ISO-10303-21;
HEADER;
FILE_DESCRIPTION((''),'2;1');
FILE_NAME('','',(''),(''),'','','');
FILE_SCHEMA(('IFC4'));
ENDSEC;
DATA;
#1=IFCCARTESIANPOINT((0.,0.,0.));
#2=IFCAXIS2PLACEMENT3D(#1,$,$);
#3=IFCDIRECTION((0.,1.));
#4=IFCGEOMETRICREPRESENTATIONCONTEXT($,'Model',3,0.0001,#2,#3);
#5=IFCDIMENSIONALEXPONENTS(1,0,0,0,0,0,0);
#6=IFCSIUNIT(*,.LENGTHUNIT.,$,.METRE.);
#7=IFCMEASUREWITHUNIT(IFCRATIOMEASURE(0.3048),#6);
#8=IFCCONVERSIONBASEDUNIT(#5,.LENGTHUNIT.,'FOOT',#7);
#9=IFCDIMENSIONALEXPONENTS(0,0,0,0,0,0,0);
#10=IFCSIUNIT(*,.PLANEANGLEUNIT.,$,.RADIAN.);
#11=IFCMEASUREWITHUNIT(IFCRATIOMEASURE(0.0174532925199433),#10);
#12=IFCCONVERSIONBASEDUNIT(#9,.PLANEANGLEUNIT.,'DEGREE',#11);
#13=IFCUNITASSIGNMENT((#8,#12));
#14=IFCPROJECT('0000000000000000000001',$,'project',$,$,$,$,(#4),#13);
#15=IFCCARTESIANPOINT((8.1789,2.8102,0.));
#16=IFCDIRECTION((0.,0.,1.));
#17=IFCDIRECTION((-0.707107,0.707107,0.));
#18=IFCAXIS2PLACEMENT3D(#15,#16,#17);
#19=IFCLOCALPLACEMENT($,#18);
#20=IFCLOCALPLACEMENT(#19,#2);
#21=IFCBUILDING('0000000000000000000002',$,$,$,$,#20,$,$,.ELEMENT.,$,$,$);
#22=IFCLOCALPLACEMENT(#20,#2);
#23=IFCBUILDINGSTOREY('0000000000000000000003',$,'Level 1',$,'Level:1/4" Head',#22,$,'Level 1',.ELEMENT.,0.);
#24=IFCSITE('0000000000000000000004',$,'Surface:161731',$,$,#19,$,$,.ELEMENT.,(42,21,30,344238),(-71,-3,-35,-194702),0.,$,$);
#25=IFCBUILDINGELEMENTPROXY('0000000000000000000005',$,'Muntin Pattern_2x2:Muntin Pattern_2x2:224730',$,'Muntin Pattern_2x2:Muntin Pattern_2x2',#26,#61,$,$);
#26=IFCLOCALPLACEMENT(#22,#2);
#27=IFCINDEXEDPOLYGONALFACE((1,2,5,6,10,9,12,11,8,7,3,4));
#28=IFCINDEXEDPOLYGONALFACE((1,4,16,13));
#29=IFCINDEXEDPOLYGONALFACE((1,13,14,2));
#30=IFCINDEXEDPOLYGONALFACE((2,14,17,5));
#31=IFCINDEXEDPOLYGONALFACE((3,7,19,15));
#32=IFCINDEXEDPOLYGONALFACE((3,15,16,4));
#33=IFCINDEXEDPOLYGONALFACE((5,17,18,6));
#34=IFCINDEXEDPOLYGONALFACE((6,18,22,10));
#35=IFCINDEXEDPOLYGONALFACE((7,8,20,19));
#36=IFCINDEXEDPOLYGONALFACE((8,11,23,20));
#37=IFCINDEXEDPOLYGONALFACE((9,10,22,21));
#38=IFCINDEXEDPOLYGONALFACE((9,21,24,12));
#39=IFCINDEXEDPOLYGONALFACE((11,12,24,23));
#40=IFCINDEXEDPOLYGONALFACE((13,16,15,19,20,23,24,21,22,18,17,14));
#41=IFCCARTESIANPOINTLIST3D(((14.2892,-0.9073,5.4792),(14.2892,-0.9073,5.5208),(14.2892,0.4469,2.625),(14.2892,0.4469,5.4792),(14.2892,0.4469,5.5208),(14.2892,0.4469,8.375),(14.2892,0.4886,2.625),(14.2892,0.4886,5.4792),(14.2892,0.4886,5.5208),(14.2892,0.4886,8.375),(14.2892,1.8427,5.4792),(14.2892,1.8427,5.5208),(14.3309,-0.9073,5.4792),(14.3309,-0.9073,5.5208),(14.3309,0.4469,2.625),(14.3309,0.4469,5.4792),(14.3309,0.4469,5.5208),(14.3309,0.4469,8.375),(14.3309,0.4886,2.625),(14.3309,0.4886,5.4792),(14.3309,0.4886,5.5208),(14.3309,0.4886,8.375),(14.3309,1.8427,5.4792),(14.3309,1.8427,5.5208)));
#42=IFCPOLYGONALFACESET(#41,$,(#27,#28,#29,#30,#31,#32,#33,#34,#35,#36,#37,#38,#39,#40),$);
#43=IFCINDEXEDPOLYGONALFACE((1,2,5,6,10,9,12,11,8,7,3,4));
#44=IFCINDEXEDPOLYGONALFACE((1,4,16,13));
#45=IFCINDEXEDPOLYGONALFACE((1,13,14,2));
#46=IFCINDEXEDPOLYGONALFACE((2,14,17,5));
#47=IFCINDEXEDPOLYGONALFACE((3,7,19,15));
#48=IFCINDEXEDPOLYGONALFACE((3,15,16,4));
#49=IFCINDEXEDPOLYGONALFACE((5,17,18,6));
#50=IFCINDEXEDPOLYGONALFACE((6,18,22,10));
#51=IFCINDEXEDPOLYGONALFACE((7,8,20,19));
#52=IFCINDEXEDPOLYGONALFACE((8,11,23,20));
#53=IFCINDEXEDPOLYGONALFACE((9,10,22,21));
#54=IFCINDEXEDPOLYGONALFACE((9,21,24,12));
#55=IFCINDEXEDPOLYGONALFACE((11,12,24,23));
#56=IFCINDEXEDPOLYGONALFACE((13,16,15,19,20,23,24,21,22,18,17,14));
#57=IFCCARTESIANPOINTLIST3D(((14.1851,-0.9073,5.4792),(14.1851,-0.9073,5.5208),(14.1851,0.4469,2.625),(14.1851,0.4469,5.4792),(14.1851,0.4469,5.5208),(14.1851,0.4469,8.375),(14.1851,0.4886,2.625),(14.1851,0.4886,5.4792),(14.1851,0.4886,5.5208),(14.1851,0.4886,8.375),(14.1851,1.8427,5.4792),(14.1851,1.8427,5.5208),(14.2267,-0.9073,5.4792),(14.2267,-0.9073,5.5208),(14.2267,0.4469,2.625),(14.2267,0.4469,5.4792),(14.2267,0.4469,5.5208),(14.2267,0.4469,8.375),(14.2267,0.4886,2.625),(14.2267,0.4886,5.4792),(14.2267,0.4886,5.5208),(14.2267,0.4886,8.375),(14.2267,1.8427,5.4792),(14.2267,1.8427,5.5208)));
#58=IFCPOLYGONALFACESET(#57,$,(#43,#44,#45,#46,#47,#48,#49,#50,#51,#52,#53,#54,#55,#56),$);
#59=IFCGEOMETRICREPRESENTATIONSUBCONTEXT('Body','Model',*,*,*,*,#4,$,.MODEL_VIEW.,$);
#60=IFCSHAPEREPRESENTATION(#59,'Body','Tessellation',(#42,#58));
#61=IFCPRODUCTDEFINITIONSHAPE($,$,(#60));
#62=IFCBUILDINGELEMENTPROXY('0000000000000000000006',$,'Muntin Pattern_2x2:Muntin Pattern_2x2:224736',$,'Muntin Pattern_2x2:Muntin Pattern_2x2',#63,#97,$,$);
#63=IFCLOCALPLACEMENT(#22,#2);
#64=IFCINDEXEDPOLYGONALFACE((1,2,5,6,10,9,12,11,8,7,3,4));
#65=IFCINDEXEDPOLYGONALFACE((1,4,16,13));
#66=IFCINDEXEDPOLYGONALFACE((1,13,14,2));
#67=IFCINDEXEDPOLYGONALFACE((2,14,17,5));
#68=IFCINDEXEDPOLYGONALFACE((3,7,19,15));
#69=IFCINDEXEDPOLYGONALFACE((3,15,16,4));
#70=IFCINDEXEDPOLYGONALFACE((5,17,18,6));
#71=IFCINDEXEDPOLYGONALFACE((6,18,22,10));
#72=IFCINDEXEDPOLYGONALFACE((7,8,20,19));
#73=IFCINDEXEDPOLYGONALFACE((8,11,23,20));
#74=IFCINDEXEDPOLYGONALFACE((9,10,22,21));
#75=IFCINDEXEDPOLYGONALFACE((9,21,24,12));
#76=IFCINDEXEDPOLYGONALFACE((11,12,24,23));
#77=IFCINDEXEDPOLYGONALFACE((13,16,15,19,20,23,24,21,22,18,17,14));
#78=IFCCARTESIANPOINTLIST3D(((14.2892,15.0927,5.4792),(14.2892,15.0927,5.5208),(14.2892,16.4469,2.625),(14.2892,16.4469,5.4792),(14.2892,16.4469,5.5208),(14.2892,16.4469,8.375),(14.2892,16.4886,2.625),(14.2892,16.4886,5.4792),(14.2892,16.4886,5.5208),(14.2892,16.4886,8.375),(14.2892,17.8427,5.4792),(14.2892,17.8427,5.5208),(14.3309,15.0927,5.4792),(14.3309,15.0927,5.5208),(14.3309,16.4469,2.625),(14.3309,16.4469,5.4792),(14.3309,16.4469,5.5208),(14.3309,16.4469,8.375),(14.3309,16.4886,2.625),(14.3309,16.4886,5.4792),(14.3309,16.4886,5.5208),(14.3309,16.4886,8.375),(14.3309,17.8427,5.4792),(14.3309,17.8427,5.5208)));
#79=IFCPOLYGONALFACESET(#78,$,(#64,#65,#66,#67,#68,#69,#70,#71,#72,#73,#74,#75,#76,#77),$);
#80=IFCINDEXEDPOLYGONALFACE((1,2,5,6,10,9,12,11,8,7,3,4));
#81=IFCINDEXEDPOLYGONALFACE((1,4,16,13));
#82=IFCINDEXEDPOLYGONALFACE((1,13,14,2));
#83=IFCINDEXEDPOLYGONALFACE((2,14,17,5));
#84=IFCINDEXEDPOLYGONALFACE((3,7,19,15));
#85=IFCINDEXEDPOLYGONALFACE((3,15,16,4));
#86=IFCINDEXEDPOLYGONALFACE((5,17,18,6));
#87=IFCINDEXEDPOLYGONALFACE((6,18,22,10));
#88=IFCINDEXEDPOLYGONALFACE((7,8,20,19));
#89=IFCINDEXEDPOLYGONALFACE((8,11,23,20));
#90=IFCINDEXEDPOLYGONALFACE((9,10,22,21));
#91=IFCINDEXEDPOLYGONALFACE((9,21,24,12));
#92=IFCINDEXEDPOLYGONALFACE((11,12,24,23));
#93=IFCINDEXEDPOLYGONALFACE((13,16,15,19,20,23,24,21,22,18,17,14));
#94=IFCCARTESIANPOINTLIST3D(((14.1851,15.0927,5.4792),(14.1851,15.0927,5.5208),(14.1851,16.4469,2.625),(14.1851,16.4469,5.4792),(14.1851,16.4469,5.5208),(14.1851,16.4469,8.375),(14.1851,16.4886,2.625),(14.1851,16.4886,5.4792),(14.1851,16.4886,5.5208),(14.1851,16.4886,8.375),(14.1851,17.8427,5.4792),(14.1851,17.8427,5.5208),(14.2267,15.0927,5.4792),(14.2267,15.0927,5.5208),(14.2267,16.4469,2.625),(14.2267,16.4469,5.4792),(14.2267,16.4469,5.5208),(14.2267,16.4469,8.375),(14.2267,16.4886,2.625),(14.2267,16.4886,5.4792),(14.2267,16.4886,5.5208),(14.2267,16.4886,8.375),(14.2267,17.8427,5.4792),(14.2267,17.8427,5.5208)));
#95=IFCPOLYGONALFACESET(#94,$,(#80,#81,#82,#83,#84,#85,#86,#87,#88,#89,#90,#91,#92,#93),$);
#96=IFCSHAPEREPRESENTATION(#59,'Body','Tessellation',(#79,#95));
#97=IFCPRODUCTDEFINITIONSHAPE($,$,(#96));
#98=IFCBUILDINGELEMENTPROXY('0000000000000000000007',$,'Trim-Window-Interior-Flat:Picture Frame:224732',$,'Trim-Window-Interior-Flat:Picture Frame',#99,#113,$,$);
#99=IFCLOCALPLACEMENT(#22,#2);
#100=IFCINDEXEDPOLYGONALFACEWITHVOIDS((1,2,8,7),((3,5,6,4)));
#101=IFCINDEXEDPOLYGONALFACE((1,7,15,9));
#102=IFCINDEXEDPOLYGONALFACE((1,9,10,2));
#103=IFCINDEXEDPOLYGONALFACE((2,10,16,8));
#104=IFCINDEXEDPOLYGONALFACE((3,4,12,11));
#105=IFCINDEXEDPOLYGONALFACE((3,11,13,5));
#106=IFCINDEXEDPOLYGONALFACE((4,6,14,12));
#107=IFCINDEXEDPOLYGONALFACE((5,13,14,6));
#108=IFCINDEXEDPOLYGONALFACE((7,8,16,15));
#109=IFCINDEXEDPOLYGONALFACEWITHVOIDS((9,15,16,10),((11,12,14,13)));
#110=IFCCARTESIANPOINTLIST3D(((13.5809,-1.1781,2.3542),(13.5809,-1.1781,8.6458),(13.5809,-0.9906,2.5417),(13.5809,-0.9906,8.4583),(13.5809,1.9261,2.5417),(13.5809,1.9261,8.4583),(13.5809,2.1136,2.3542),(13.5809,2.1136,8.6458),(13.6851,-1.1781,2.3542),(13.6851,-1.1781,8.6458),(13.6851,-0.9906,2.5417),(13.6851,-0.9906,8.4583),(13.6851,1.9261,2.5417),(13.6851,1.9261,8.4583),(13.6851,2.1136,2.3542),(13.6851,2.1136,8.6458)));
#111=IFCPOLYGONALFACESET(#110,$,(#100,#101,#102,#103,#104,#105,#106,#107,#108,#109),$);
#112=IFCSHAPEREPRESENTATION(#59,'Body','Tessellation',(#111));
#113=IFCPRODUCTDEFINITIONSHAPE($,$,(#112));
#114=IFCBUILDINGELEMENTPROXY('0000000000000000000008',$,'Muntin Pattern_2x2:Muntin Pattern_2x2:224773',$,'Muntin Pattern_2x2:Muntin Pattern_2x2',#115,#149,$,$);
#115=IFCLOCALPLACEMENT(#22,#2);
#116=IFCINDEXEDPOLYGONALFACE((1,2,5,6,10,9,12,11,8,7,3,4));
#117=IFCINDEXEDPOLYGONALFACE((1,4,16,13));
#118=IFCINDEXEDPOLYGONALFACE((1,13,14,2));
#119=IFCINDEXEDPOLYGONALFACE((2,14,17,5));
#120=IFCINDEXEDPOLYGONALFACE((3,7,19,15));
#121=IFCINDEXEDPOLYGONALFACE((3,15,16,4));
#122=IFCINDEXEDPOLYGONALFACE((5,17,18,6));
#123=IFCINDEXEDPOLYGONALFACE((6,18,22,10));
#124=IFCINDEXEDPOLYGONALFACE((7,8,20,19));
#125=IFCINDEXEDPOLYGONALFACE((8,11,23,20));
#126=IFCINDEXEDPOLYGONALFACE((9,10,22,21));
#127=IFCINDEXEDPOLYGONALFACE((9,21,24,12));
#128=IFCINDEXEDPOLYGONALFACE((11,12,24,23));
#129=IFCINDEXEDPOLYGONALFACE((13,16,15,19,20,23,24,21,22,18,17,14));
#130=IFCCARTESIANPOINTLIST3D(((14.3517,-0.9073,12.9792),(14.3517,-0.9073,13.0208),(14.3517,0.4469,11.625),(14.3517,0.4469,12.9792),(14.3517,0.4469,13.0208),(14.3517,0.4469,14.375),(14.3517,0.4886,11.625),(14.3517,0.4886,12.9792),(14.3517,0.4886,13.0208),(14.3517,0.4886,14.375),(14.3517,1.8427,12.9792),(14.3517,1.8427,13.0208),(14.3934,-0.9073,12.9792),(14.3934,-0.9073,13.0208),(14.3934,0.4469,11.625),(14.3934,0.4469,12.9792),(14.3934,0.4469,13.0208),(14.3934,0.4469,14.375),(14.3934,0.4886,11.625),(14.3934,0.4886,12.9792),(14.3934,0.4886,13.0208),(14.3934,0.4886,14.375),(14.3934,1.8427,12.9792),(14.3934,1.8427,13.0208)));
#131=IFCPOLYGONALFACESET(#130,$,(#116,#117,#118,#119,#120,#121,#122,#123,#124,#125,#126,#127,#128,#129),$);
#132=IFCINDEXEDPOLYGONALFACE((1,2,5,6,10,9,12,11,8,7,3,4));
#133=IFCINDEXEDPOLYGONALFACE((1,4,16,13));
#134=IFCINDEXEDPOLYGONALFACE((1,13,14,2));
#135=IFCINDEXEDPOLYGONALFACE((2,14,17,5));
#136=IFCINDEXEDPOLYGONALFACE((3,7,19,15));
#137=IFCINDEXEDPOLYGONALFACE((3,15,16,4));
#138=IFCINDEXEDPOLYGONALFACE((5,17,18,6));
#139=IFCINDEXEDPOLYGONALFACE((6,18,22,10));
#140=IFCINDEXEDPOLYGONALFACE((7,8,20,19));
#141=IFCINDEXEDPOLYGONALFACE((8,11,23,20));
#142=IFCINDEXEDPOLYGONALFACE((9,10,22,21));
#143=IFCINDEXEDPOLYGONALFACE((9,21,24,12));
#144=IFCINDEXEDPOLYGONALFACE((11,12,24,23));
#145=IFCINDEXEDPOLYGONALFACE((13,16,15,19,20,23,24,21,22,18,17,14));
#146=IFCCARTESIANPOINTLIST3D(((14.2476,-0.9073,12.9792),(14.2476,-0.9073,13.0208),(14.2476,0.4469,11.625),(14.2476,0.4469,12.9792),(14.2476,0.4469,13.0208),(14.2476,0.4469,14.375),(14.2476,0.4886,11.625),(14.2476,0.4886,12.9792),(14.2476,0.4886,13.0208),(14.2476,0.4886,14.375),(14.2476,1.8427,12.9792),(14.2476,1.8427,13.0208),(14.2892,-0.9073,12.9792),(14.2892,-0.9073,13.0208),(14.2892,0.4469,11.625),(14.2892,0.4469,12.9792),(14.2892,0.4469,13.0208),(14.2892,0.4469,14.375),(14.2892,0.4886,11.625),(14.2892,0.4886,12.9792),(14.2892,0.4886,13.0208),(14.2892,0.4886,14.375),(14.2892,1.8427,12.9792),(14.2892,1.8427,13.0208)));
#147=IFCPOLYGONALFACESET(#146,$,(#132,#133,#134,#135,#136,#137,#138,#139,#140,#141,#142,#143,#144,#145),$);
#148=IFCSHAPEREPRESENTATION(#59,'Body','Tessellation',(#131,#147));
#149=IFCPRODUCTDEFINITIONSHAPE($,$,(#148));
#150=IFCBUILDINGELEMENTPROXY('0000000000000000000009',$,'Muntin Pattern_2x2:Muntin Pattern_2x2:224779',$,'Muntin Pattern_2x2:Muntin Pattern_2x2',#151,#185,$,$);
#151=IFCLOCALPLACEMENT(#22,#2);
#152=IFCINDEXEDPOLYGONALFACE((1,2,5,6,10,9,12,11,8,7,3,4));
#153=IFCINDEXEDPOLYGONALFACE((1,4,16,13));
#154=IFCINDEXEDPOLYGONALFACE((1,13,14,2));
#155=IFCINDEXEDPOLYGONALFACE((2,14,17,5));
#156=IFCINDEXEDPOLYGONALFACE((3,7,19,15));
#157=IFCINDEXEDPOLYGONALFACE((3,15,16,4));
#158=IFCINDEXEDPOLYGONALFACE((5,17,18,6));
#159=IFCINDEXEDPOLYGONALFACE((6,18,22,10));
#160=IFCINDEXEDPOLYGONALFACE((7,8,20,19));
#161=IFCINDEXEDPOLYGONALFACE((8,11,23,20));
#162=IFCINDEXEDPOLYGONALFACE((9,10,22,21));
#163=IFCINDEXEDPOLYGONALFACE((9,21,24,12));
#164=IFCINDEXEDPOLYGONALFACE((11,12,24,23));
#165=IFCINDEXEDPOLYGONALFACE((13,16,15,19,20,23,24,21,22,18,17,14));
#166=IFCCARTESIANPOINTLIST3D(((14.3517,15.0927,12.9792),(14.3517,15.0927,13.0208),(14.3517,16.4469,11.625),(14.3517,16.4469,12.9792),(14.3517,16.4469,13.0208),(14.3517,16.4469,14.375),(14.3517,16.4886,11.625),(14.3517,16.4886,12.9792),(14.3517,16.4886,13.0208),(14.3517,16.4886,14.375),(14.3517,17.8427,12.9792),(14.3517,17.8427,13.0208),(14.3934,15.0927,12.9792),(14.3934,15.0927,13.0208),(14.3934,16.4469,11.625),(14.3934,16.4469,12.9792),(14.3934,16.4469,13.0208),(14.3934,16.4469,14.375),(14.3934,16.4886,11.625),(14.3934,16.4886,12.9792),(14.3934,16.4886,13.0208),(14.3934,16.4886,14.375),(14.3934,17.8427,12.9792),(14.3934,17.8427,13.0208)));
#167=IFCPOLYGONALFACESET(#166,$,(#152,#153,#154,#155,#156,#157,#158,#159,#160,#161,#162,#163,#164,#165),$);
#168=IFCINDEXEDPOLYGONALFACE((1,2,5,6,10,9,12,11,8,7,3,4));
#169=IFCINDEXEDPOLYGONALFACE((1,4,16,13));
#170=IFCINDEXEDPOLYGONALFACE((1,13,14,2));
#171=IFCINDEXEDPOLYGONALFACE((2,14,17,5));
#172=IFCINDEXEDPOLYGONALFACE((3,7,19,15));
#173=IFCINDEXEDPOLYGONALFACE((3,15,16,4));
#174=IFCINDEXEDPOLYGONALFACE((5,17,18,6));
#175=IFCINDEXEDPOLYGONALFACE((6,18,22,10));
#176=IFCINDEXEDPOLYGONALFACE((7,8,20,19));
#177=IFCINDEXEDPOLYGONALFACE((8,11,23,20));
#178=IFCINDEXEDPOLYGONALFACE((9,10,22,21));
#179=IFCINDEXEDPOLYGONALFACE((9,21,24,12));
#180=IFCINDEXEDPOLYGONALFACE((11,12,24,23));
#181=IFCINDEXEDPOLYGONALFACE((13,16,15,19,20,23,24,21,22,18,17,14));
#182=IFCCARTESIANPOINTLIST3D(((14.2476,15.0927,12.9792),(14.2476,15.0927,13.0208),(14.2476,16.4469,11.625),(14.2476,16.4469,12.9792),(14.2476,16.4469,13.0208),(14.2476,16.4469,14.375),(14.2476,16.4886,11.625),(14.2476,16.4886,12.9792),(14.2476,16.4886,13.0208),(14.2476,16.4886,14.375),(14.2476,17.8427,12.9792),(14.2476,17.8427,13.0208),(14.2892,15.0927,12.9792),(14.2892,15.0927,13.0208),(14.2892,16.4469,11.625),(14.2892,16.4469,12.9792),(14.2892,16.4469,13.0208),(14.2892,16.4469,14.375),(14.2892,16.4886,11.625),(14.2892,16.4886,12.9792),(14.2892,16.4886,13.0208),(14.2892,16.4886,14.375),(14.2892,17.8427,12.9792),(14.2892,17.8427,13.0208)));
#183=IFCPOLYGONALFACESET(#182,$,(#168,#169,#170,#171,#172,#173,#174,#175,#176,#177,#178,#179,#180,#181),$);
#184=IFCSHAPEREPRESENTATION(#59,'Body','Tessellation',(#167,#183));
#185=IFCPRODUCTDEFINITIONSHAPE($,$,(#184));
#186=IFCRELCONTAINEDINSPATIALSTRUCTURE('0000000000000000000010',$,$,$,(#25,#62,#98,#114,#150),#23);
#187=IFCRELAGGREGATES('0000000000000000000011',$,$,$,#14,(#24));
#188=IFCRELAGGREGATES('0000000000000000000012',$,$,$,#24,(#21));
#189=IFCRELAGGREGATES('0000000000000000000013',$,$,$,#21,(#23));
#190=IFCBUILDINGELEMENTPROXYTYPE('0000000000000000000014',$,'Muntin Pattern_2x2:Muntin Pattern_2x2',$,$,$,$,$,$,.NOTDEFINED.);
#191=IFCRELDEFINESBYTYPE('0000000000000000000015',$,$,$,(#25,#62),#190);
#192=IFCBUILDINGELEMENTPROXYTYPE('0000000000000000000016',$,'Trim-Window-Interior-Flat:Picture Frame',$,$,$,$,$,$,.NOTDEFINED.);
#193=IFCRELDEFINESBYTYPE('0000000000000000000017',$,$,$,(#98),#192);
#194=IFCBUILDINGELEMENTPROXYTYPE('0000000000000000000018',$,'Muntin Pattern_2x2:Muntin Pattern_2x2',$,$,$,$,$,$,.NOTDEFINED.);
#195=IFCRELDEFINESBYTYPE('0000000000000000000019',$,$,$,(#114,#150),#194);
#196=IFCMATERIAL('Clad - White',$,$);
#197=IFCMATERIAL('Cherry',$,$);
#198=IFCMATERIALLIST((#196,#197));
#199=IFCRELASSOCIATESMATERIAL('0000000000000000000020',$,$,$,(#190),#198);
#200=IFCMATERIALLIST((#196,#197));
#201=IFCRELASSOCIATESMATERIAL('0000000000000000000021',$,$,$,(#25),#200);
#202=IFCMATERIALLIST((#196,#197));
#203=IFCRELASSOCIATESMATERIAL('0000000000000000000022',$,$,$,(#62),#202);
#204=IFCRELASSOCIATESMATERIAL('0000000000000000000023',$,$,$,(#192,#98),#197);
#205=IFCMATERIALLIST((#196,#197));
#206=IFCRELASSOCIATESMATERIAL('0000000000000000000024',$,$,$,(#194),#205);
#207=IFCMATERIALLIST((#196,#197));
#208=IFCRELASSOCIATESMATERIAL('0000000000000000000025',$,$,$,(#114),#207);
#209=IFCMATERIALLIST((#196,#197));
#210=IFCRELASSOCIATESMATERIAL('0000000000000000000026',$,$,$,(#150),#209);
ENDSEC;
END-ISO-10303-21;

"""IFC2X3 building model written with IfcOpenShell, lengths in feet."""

from ifc_helpers import new_model, entity, si_unit, converted_unit, direction, frame, origin, place, context, subcontext, project, spatial, polyline, outline, extrude, source, transform, mapped, material, material_list, type_object, type_shapes, element, save


model = new_model("IFC2X3")

# Units and contexts
model_context = context("Model", 3, precision=0.0001, world=origin(), true_north=direction((0.0, 1.0)))
body_context = subcontext(model_context, "Body", "Model", "MODEL_VIEW")
ifc_project = project(units=[converted_unit("LENGTHUNIT", "FOOT", entity("IfcRatioMeasure", 0.3048), si_unit("LENGTHUNIT", "METRE"), dimensions=[1, 0, 0, 0, 0, 0, 0]), converted_unit("PLANEANGLEUNIT", "DEGREE", entity("IfcRatioMeasure", 0.0174532925199433), si_unit("PLANEANGLEUNIT", "RADIAN"), dimensions=[0, 0, 0, 0, 0, 0, 0])], contexts=[model_context])

# Site, building, storey
site_placement = place(None, frame((8.1789, 2.8102, 0.0), z_axis=(0.0, 0.0, 1.0), x_axis=(-0.707107, 0.707107, 0.0)))
site = spatial("IfcSite", under=ifc_project, at=site_placement, Name="Surface:161731", CompositionType="ELEMENT", RefLatitude=(42, 21, 30, 344238), RefLongitude=(-71, -3, -35, -194702), RefElevation=0.0)
building_placement = place(site_placement, origin())
building = spatial("IfcBuilding", under=site, at=building_placement, CompositionType="ELEMENT")
storey_placement = place(building_placement, origin())
storey = spatial("IfcBuildingStorey", under=building, at=storey_placement, Name="Level 1", ObjectType="Level:1/4\" Head", LongName="Level 1", CompositionType="ELEMENT", Elevation=0.0)

# Building element proxies
ifc_material_1 = material(Name="Clad - White")
ifc_material_2 = material(Name="Cherry")
ifc_material_list_1 = material_list([ifc_material_1, ifc_material_2])
ifc_material_list_2 = material_list([ifc_material_1, ifc_material_2])
building_element_proxy_type_1 = type_object("IfcBuildingElementProxyType", Name="Muntin Pattern_2x2:Muntin Pattern_2x2", PredefinedType="NOTDEFINED", material=ifc_material_list_2)
shared_shape_1 = source(origin(), body_context, "Body", "SweptSolid", [
    extrude(outline(polyline([(0.0208, -0.0208), (2.875, -0.0208), (2.875, 0.0208), (0.0208, 0.0208), (0.0208, 1.375), (-0.0208, 1.375), (-0.0208, 0.0208), (-2.875, 0.0208), (-2.875, -0.0208), (-0.0208, -0.0208), (-0.0208, -1.375), (0.0208, -1.375), (0.0208, -0.0208)])), frame((0.0, 0.0313, 2.875), z_axis=(0.0, 1.0, 0.0), x_axis=(0.0, 0.0, 1.0)), (0.0, 0.0, 1.0), 0.0417),
    extrude(outline(polyline([(0.0208, -0.0208), (2.875, -0.0208), (2.875, 0.0208), (0.0208, 0.0208), (0.0208, 1.375), (-0.0208, 1.375), (-0.0208, 0.0208), (-2.875, 0.0208), (-2.875, -0.0208), (-0.0208, -0.0208), (-0.0208, -1.375), (0.0208, -1.375), (0.0208, -0.0208)])), frame((0.0, -0.0729, 2.875), z_axis=(0.0, 1.0, 0.0), x_axis=(0.0, 0.0, 1.0)), (0.0, 0.0, 1.0), 0.0417),
])
type_shapes(building_element_proxy_type_1, [shared_shape_1])
proxy_1_placement = place(storey_placement, frame((14.258, 0.4677, 2.625), z_axis=(0.0, 0.0, 1.0), x_axis=(0.0, -1.0, 0.0)))
element("IfcBuildingElementProxy", 1, at=proxy_1_placement, inside=storey, type_object=building_element_proxy_type_1, material=ifc_material_list_1, Name="Muntin Pattern_2x2:Muntin Pattern_2x2:224730", ObjectType="Muntin Pattern_2x2:Muntin Pattern_2x2", context=body_context, shape_type="MappedRepresentation", body=[
    mapped(shared_shape_1, transform((0.0, 0.0, 0.0), scale=1.0)),
])
ifc_material_list_3 = material_list([ifc_material_1, ifc_material_2])
proxy_2_placement = place(storey_placement, frame((14.258, 16.4677, 2.625), z_axis=(0.0, 0.0, 1.0), x_axis=(0.0, -1.0, 0.0)))
element("IfcBuildingElementProxy", 2, at=proxy_2_placement, inside=storey, type_object=building_element_proxy_type_1, material=ifc_material_list_3, Name="Muntin Pattern_2x2:Muntin Pattern_2x2:224736", ObjectType="Muntin Pattern_2x2:Muntin Pattern_2x2", context=body_context, shape_type="MappedRepresentation", body=[
    mapped(shared_shape_1, transform((0.0, 0.0, 0.0), scale=1.0)),
])
building_element_proxy_type_2 = type_object("IfcBuildingElementProxyType", Name="Trim-Window-Interior-Flat:Picture Frame", PredefinedType="NOTDEFINED", material=ifc_material_2)
shared_shape_2 = source(origin(), body_context, "Body", "SweptSolid", [
    extrude(outline(polyline([(-3.1458, -1.6458), (3.1458, -1.6458), (3.1458, 1.6458), (-3.1458, 1.6458), (-3.1458, -1.6458)]), holes=[polyline([(-2.9583, -1.4583), (-2.9583, 1.4583), (2.9583, 1.4583), (2.9583, -1.4583), (-2.9583, -1.4583)])]), frame((0.0, 3.0, 0.0), z_axis=(0.0, 0.0, 1.0), x_axis=(0.0, 1.0, 0.0)), (0.0, 0.0, 1.0), 0.1042),
])
type_shapes(building_element_proxy_type_2, [shared_shape_2])
proxy_3_placement = place(storey_placement, frame((13.6851, 0.4677, 8.5), z_axis=(-1.0, 0.0, 0.0), x_axis=(0.0, 1.0, 0.0)))
element("IfcBuildingElementProxy", 3, at=proxy_3_placement, inside=storey, type_object=building_element_proxy_type_2, material=ifc_material_2, Name="Trim-Window-Interior-Flat:Picture Frame:224732", ObjectType="Trim-Window-Interior-Flat:Picture Frame", context=body_context, shape_type="MappedRepresentation", body=[
    mapped(shared_shape_2, transform((0.0, 0.0, 0.0), scale=1.0)),
])
ifc_material_list_4 = material_list([ifc_material_1, ifc_material_2])
ifc_material_list_5 = material_list([ifc_material_1, ifc_material_2])
building_element_proxy_type_3 = type_object("IfcBuildingElementProxyType", Name="Muntin Pattern_2x2:Muntin Pattern_2x2", PredefinedType="NOTDEFINED", material=ifc_material_list_5)
shared_shape_3 = source(origin(), body_context, "Body", "SweptSolid", [
    extrude(outline(polyline([(0.0208, -0.0208), (1.375, -0.0208), (1.375, 0.0208), (0.0208, 0.0208), (0.0208, 1.375), (-0.0208, 1.375), (-0.0208, 0.0208), (-1.375, 0.0208), (-1.375, -0.0208), (-0.0208, -0.0208), (-0.0208, -1.375), (0.0208, -1.375), (0.0208, -0.0208)])), frame((0.0, 0.0312, 1.375), z_axis=(0.0, 1.0, 0.0), x_axis=(0.0, 0.0, 1.0)), (0.0, 0.0, 1.0), 0.0417),
    extrude(outline(polyline([(0.0208, -0.0208), (1.375, -0.0208), (1.375, 0.0208), (0.0208, 0.0208), (0.0208, 1.375), (-0.0208, 1.375), (-0.0208, 0.0208), (-1.375, 0.0208), (-1.375, -0.0208), (-0.0208, -0.0208), (-0.0208, -1.375), (0.0208, -1.375), (0.0208, -0.0208)])), frame((0.0, -0.0729, 1.375), z_axis=(0.0, 1.0, 0.0), x_axis=(0.0, 0.0, 1.0)), (0.0, 0.0, 1.0), 0.0417),
])
type_shapes(building_element_proxy_type_3, [shared_shape_3])
proxy_4_placement = place(storey_placement, frame((14.3205, 0.4677, 11.625), z_axis=(0.0, 0.0, 1.0), x_axis=(0.0, -1.0, 0.0)))
element("IfcBuildingElementProxy", 4, at=proxy_4_placement, inside=storey, type_object=building_element_proxy_type_3, material=ifc_material_list_4, Name="Muntin Pattern_2x2:Muntin Pattern_2x2:224773", ObjectType="Muntin Pattern_2x2:Muntin Pattern_2x2", context=body_context, shape_type="MappedRepresentation", body=[
    mapped(shared_shape_3, transform((0.0, 0.0, 0.0), scale=1.0)),
])
ifc_material_list_6 = material_list([ifc_material_1, ifc_material_2])
proxy_5_placement = place(storey_placement, frame((14.3205, 16.4677, 11.625), z_axis=(0.0, 0.0, 1.0), x_axis=(0.0, -1.0, 0.0)))
element("IfcBuildingElementProxy", 5, at=proxy_5_placement, inside=storey, type_object=building_element_proxy_type_3, material=ifc_material_list_6, Name="Muntin Pattern_2x2:Muntin Pattern_2x2:224779", ObjectType="Muntin Pattern_2x2:Muntin Pattern_2x2", context=body_context, shape_type="MappedRepresentation", body=[
    mapped(shared_shape_3, transform((0.0, 0.0, 0.0), scale=1.0)),
])

save(model, "model.ifc")
